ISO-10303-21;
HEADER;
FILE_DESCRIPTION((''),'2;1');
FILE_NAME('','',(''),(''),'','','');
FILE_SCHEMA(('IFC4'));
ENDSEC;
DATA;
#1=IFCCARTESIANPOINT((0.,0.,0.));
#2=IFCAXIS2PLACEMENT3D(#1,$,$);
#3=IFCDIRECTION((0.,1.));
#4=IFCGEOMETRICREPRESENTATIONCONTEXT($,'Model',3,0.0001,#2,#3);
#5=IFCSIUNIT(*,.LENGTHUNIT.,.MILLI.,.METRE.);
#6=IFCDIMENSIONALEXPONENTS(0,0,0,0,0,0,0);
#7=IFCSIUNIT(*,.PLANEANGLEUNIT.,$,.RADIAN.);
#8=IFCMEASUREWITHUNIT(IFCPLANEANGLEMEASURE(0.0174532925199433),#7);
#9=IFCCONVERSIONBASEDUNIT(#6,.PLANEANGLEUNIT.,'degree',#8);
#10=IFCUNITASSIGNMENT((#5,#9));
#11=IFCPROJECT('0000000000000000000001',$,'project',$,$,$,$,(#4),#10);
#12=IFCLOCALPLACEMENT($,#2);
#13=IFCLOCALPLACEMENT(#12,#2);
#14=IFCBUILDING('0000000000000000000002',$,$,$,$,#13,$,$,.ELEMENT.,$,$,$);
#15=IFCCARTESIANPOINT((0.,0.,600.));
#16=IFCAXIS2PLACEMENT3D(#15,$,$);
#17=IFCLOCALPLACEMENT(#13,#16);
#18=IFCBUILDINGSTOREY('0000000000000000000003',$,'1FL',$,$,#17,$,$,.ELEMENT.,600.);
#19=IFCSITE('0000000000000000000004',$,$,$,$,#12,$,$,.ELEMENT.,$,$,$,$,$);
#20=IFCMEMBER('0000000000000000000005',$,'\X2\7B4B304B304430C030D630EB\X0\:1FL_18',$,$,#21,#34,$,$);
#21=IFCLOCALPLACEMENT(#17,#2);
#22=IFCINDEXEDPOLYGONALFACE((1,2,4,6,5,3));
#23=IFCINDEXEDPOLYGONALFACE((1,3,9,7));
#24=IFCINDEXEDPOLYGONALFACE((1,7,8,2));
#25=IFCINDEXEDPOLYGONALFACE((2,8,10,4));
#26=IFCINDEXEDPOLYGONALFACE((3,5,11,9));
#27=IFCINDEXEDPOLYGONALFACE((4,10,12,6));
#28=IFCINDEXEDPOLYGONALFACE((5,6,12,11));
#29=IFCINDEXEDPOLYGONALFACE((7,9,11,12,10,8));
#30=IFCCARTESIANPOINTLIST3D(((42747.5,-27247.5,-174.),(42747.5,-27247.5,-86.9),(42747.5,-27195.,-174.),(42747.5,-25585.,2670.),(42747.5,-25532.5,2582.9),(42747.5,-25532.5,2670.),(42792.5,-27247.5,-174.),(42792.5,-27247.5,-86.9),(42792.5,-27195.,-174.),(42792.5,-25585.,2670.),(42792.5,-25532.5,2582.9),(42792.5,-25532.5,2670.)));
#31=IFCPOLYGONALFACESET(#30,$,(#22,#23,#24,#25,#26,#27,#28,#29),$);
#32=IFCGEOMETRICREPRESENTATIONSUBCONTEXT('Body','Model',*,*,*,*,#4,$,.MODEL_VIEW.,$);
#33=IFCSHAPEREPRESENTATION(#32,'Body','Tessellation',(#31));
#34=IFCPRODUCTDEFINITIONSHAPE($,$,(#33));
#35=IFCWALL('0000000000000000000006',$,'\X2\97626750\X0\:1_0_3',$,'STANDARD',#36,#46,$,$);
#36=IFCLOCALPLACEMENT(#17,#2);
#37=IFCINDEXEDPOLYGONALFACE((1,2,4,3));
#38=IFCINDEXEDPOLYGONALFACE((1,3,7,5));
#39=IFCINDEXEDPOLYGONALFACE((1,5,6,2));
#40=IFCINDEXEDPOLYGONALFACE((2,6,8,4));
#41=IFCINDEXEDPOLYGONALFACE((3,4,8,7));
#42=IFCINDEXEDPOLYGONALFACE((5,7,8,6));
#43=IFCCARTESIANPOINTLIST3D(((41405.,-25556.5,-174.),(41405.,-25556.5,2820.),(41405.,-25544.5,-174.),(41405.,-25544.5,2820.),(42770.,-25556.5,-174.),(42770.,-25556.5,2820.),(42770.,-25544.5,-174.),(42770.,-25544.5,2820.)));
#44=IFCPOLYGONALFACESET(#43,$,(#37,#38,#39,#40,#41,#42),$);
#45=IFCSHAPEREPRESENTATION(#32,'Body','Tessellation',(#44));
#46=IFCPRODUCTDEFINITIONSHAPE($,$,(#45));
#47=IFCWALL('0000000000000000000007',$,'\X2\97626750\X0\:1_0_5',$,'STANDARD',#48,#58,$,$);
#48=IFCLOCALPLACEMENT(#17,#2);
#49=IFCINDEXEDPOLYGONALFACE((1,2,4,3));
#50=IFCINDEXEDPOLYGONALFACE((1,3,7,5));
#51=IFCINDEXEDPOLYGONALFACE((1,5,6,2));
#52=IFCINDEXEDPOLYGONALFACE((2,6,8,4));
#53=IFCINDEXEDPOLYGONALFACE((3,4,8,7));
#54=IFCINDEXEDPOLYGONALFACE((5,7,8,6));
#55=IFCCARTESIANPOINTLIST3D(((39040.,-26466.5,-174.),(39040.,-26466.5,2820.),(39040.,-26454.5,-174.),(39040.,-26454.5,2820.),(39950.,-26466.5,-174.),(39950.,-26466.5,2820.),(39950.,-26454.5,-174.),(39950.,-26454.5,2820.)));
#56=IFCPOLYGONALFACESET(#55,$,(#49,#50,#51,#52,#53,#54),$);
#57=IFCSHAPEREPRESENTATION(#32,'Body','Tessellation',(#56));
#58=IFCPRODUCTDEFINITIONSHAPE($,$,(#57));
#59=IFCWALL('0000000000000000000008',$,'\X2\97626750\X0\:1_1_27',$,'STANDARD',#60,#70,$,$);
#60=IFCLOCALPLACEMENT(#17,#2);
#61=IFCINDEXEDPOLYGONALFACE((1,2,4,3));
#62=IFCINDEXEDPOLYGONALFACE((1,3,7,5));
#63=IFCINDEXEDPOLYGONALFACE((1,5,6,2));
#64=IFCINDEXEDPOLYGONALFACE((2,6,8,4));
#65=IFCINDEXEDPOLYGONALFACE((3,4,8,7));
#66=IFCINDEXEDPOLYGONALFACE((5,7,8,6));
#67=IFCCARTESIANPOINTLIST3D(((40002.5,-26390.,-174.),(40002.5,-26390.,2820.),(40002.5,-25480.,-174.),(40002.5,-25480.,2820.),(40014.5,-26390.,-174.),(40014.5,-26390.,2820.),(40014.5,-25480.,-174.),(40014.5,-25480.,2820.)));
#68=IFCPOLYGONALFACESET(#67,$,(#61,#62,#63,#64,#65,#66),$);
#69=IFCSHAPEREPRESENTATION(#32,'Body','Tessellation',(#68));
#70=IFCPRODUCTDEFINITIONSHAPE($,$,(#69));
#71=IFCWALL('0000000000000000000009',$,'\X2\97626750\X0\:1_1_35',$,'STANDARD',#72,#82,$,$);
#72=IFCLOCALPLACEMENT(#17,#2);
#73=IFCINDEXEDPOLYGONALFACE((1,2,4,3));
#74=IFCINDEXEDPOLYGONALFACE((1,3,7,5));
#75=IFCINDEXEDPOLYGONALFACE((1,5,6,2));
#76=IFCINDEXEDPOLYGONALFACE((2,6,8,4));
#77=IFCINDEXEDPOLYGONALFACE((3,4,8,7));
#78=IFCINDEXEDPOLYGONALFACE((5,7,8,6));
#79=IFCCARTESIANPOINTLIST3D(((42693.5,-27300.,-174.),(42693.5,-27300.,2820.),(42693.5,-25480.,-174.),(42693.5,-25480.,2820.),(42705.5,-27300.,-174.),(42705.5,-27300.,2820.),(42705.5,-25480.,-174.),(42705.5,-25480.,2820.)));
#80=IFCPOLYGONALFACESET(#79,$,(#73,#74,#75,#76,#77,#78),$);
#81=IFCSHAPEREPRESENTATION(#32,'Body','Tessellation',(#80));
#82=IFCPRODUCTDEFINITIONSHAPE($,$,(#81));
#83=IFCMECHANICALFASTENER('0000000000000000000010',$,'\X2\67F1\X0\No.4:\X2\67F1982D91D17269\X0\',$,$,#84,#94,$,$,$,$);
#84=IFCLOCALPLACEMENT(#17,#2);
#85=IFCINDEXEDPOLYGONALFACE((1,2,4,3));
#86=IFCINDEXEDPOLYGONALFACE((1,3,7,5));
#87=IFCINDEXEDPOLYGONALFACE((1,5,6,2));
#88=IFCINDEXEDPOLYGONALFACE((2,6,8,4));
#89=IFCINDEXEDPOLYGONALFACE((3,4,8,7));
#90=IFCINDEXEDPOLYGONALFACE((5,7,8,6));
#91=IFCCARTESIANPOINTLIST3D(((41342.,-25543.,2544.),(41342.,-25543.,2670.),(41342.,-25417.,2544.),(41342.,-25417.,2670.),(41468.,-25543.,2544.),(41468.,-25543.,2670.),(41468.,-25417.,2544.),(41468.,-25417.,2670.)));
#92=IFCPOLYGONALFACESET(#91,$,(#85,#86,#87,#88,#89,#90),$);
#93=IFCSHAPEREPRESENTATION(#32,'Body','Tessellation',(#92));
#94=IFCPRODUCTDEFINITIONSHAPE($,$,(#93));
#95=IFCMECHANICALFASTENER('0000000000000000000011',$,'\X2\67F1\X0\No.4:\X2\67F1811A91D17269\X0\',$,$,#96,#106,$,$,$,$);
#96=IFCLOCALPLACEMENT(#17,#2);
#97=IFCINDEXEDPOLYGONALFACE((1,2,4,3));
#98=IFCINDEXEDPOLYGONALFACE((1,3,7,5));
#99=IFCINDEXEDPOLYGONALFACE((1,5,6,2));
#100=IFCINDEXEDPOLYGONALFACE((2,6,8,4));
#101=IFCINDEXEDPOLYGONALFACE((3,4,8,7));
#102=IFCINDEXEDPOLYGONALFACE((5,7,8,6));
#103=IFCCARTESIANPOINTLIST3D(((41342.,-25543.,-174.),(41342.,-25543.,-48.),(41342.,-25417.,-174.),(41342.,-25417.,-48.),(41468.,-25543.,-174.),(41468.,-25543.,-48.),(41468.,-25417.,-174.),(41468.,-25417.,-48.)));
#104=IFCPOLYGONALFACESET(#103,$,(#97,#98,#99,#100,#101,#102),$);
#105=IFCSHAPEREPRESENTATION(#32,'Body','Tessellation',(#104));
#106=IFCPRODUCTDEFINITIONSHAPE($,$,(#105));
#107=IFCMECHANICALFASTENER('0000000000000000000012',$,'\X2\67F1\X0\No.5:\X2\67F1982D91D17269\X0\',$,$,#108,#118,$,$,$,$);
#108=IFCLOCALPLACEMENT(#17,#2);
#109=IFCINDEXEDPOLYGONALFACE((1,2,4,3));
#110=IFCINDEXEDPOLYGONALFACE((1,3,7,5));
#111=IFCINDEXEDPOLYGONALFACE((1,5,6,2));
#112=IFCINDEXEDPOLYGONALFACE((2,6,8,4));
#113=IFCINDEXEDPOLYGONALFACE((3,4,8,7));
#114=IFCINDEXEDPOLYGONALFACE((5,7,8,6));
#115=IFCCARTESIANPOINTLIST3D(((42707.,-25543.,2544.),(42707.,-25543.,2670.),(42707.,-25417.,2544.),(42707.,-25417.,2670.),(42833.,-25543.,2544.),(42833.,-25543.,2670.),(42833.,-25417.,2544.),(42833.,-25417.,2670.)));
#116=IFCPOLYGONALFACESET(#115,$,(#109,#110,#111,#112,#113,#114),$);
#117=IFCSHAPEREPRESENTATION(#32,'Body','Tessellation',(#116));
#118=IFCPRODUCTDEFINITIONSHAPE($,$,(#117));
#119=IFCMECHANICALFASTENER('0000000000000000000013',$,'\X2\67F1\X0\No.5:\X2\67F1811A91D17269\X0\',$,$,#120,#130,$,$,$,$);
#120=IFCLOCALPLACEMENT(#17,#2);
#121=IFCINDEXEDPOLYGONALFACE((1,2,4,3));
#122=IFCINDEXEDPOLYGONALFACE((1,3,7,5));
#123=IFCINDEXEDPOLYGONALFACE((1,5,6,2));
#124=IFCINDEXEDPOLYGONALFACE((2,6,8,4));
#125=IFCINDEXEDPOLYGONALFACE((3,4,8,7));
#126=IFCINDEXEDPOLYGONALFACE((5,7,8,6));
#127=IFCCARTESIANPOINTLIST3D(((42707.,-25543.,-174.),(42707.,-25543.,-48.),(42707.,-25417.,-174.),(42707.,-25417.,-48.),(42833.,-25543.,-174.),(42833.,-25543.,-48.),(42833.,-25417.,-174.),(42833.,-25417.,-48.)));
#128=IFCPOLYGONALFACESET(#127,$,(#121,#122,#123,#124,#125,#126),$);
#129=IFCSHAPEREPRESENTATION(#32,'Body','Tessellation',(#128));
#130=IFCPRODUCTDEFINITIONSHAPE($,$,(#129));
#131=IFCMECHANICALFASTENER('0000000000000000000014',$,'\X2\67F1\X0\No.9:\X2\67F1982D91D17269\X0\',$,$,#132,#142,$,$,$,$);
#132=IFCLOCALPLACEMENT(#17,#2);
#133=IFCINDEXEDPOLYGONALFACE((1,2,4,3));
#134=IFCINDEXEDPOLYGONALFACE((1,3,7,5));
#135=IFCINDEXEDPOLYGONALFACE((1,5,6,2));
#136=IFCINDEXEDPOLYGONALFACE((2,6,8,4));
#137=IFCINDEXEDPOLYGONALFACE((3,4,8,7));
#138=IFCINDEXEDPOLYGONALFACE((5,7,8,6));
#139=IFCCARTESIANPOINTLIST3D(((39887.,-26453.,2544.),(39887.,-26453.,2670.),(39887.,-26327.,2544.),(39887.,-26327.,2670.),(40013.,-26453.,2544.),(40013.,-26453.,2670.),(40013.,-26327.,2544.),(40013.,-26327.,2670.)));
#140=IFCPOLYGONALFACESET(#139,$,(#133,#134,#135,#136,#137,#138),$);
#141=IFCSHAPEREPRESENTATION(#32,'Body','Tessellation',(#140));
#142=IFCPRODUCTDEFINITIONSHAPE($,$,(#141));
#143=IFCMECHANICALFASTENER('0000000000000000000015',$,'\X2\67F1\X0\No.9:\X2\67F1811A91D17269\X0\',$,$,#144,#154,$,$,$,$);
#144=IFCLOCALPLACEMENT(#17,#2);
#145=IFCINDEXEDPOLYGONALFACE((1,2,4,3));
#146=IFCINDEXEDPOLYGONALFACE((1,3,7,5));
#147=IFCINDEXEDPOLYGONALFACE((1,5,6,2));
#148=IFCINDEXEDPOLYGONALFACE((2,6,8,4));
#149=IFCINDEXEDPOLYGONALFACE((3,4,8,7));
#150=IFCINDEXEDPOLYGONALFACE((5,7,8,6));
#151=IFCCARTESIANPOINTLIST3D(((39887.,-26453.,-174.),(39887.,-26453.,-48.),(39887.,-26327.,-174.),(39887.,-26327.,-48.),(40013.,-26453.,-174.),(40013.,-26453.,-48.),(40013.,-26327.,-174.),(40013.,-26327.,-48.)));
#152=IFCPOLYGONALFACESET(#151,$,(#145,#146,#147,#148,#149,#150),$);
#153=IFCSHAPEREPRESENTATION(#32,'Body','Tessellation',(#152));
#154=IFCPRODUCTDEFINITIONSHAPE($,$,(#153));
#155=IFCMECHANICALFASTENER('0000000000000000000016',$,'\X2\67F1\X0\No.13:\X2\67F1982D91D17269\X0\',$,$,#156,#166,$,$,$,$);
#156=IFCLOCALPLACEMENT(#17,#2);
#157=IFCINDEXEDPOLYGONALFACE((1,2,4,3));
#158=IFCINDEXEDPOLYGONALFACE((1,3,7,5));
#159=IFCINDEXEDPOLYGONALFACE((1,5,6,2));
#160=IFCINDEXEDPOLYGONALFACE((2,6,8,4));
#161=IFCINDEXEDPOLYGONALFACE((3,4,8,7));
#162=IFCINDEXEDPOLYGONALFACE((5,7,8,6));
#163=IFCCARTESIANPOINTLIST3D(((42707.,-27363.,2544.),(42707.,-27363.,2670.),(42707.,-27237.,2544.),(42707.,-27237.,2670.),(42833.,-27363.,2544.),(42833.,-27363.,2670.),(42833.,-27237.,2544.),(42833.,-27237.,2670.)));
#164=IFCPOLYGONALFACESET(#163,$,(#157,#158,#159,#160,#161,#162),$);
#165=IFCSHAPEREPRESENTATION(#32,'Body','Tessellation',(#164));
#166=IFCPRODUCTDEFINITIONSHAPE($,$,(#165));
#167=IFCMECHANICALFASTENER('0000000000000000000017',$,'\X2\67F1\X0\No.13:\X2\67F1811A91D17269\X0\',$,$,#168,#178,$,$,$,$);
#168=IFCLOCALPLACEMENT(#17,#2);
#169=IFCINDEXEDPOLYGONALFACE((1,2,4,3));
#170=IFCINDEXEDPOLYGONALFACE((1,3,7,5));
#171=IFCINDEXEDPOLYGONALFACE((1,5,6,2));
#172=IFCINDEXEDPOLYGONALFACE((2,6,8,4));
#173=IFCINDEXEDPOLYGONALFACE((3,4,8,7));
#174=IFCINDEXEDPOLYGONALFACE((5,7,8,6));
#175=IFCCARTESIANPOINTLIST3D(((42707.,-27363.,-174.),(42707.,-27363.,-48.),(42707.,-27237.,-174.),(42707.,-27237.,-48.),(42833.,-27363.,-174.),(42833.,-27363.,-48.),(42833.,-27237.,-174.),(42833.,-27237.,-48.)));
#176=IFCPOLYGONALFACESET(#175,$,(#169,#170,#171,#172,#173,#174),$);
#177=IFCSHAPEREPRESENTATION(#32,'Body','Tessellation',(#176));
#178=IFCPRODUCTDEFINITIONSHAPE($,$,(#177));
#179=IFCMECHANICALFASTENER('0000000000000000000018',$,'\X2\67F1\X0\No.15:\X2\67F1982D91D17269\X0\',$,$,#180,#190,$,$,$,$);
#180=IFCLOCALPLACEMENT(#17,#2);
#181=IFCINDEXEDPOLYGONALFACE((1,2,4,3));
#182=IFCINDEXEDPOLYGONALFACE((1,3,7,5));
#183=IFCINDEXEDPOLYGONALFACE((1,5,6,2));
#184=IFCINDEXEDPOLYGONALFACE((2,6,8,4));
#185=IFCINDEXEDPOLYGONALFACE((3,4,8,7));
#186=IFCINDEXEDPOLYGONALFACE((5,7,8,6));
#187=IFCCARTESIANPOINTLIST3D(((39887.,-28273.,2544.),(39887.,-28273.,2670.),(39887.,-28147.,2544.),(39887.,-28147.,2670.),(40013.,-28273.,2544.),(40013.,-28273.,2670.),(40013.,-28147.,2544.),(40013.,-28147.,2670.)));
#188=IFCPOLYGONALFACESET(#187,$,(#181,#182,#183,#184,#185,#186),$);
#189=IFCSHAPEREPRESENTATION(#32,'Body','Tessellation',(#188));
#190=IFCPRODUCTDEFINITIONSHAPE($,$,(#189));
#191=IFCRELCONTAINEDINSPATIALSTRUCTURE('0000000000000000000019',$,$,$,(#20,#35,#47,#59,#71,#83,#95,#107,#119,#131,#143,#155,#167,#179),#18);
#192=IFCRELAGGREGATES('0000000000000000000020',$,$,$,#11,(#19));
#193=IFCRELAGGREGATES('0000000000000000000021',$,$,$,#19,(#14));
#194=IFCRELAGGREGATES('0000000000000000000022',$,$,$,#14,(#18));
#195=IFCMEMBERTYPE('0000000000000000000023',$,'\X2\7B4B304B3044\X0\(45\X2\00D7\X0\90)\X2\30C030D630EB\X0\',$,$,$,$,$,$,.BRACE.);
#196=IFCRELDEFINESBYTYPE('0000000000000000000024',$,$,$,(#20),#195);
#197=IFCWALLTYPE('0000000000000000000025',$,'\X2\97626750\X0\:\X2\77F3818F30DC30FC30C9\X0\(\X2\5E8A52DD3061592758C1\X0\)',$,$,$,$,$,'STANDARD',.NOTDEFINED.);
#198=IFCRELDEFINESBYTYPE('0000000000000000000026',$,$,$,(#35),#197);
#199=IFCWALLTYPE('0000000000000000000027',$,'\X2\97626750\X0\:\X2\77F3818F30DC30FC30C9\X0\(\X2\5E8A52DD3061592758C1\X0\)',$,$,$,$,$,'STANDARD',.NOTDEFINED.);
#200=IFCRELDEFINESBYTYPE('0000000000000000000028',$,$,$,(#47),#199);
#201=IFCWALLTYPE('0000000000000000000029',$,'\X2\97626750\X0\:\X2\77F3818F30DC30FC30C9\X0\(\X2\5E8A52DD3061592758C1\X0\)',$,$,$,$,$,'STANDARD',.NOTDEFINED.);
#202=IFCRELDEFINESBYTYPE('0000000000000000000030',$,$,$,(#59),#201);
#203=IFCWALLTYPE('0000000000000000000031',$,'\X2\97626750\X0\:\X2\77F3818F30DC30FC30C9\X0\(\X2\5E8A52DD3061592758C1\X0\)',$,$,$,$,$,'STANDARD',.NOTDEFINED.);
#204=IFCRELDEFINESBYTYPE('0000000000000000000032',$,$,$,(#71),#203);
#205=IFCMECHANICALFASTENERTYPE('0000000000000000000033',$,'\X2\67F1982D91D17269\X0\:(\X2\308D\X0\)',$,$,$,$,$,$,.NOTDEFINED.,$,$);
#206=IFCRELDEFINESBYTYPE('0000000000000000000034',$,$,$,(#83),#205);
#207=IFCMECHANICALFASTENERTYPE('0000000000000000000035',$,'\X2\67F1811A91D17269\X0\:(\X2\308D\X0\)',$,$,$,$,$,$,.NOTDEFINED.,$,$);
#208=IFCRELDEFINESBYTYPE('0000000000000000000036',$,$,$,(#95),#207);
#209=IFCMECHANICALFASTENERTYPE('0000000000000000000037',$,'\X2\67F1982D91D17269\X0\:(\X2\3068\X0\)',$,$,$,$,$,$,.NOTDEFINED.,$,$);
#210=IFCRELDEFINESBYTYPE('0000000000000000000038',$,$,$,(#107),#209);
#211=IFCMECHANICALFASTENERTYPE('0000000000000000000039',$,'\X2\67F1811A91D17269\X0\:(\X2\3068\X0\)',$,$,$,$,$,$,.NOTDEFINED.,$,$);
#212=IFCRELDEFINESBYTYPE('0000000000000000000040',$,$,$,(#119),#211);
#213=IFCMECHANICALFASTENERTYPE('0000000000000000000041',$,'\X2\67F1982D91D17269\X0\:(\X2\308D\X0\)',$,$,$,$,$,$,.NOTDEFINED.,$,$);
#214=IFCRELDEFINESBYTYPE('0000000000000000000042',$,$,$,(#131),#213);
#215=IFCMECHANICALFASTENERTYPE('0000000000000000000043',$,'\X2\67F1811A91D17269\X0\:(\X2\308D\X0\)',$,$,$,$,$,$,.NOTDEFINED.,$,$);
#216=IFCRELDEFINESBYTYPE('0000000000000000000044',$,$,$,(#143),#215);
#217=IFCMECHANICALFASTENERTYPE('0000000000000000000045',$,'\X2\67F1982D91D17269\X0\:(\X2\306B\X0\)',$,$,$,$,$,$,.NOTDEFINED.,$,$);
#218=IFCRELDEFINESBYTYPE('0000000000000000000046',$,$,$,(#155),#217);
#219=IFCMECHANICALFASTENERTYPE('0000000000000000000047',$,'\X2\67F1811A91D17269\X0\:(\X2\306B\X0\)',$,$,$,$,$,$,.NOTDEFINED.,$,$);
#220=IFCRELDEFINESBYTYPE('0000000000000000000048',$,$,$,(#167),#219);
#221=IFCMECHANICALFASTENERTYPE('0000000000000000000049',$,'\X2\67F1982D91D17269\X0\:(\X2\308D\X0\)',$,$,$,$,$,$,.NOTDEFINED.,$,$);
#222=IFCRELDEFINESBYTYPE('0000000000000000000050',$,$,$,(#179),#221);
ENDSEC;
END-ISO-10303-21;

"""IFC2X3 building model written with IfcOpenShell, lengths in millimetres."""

from ifc_helpers import new_model, entity, si_unit, converted_unit, direction, frame, origin, origin_with_axes, origin_2d, place, context, subcontext, project, spatial, polyline, rectangle, outline, extrude, type_object, element, save


model = new_model("IFC2X3")

# Units and contexts
model_context = context("Model", 3, precision=0.0001, world=origin(), true_north=direction((0.0, 1.0)))
body_context = subcontext(model_context, "Body", "Model", "MODEL_VIEW")
ifc_project = project(units=[si_unit("LENGTHUNIT", "METRE", prefix="MILLI"), converted_unit("PLANEANGLEUNIT", "degree", entity("IfcPlaneAngleMeasure", 0.0174532925199433), si_unit("PLANEANGLEUNIT", "RADIAN"), dimensions=[0, 0, 0, 0, 0, 0, 0])], contexts=[model_context])

# Site, building, storey
site_placement = place(None, origin())
site = spatial("IfcSite", under=ifc_project, at=site_placement, CompositionType="ELEMENT")
building_placement = place(site_placement, origin())
building = spatial("IfcBuilding", under=site, at=building_placement, CompositionType="ELEMENT")
storey_placement = place(building_placement, frame((0.0, 0.0, 600.0)))
storey = spatial("IfcBuildingStorey", under=building, at=storey_placement, Name="1FL", CompositionType="ELEMENT", Elevation=600.0)

# Member
member_type_1 = type_object("IfcMemberType", Name="筋かい(45×90)ダブル", PredefinedType="BRACE")
member_1_placement = place(storey_placement, frame((42770.0, -27247.5, -174.0), z_axis=(0.0, 0.516399, 0.856348), x_axis=(0.0, -0.856348, 0.516399)))
element("IfcMember", 1, at=member_1_placement, inside=storey, type_object=member_type_1, Name="筋かいダブル:1FL_18", context=body_context, shape_type="SweptSolid", body=[
    extrude(outline(polyline([(0.0, 0.0), (27.1, -45.0), (3246.5, -45.0), (3321.1, 0.0), (3293.9, 45.0), (74.6, 45.0), (0.0, 0.0)])), frame((0.0, -22.5, 0.0), z_axis=(0.0, 1.0, 0.0), x_axis=(0.0, 0.0, 1.0)), (0.0, 0.0, 1.0), 45.0),
])

# Walls
wall_type_1 = type_object("IfcWallType", Name="面材:石膏ボード(床勝ち大壁)", ElementType="STANDARD", PredefinedType="NOTDEFINED")
wall_1_placement = place(storey_placement, frame((42087.5, -25544.5, -174.0), z_axis=(0.0, -1.0, 0.0), x_axis=(1.0, 0.0, 0.0)))
element("IfcWall", 2, at=wall_1_placement, inside=storey, type_object=wall_type_1, Name="面材:1_0_3", ObjectType="STANDARD", context=body_context, shape_type="SweptSolid", body=[
    extrude(outline(polyline([(682.5, 0.0, 0.0), (-682.5, 0.0, 0.0), (-682.5, 2994.0, 0.0), (682.5, 2994.0, 0.0), (682.5, 0.0, 0.0)])), origin_with_axes(), (0.0, 0.0, 1.0), 12.0),
])
wall_type_2 = type_object("IfcWallType", Name="面材:石膏ボード(床勝ち大壁)", ElementType="STANDARD", PredefinedType="NOTDEFINED")
wall_2_placement = place(storey_placement, frame((39495.0, -26454.5, -174.0), z_axis=(0.0, -1.0, 0.0), x_axis=(1.0, 0.0, 0.0)))
element("IfcWall", 3, at=wall_2_placement, inside=storey, type_object=wall_type_2, Name="面材:1_0_5", ObjectType="STANDARD", context=body_context, shape_type="SweptSolid", body=[
    extrude(outline(polyline([(455.0, 0.0, 0.0), (-455.0, 0.0, 0.0), (-455.0, 2994.0, 0.0), (455.0, 2994.0, 0.0), (455.0, 0.0, 0.0)])), origin_with_axes(), (0.0, 0.0, 1.0), 12.0),
])
wall_type_3 = type_object("IfcWallType", Name="面材:石膏ボード(床勝ち大壁)", ElementType="STANDARD", PredefinedType="NOTDEFINED")
wall_3_placement = place(storey_placement, frame((40014.5, -25935.0, -174.0), z_axis=(-1.0, 0.0, 0.0), x_axis=(0.0, -1.0, 0.0)))
element("IfcWall", 4, at=wall_3_placement, inside=storey, type_object=wall_type_3, Name="面材:1_1_27", ObjectType="STANDARD", context=body_context, shape_type="SweptSolid", body=[
    extrude(outline(polyline([(455.0, 0.0, 0.0), (-455.0, 0.0, 0.0), (-455.0, 2994.0, 0.0), (455.0, 2994.0, 0.0), (455.0, 0.0, 0.0)])), origin_with_axes(), (0.0, 0.0, 1.0), 12.0),
])
wall_type_4 = type_object("IfcWallType", Name="面材:石膏ボード(床勝ち大壁)", ElementType="STANDARD", PredefinedType="NOTDEFINED")
wall_4_placement = place(storey_placement, frame((42705.5, -26390.0, -174.0), z_axis=(-1.0, 0.0, 0.0), x_axis=(0.0, -1.0, 0.0)))
element("IfcWall", 5, at=wall_4_placement, inside=storey, type_object=wall_type_4, Name="面材:1_1_35", ObjectType="STANDARD", context=body_context, shape_type="SweptSolid", body=[
    extrude(outline(polyline([(910.0, 0.0, 0.0), (-910.0, 0.0, 0.0), (-910.0, 2994.0, 0.0), (910.0, 2994.0, 0.0), (910.0, 0.0, 0.0)])), origin_with_axes(), (0.0, 0.0, 1.0), 12.0),
])

# Mechanical fasteners
mechanical_fastener_type_1 = type_object("IfcMechanicalFastenerType", Name="柱頭金物:(ろ)")
mechanical_fastener_1_placement = place(storey_placement, frame((41405.0, -25480.0, 2544.0)))
element("IfcMechanicalFastener", 6, at=mechanical_fastener_1_placement, inside=storey, type_object=mechanical_fastener_type_1, Name="柱No.4:柱頭金物", context=body_context, shape_type="SweptSolid", body=[
    extrude(rectangle(XDim=126.0, YDim=126.0, at=origin_2d()), origin_with_axes(), (0.0, 0.0, 1.0), 126.0),
])
mechanical_fastener_type_2 = type_object("IfcMechanicalFastenerType", Name="柱脚金物:(ろ)")
mechanical_fastener_2_placement = place(storey_placement, frame((41405.0, -25480.0, -174.0)))
element("IfcMechanicalFastener", 7, at=mechanical_fastener_2_placement, inside=storey, type_object=mechanical_fastener_type_2, Name="柱No.4:柱脚金物", context=body_context, shape_type="SweptSolid", body=[
    extrude(rectangle(XDim=126.0, YDim=126.0, at=origin_2d()), origin_with_axes(), (0.0, 0.0, 1.0), 126.0),
])
mechanical_fastener_type_3 = type_object("IfcMechanicalFastenerType", Name="柱頭金物:(と)")
mechanical_fastener_3_placement = place(storey_placement, frame((42770.0, -25480.0, 2544.0)))
element("IfcMechanicalFastener", 8, at=mechanical_fastener_3_placement, inside=storey, type_object=mechanical_fastener_type_3, Name="柱No.5:柱頭金物", context=body_context, shape_type="SweptSolid", body=[
    extrude(rectangle(XDim=126.0, YDim=126.0, at=origin_2d()), origin_with_axes(), (0.0, 0.0, 1.0), 126.0),
])
mechanical_fastener_type_4 = type_object("IfcMechanicalFastenerType", Name="柱脚金物:(と)")
mechanical_fastener_4_placement = place(storey_placement, frame((42770.0, -25480.0, -174.0)))
element("IfcMechanicalFastener", 9, at=mechanical_fastener_4_placement, inside=storey, type_object=mechanical_fastener_type_4, Name="柱No.5:柱脚金物", context=body_context, shape_type="SweptSolid", body=[
    extrude(rectangle(XDim=126.0, YDim=126.0, at=origin_2d()), origin_with_axes(), (0.0, 0.0, 1.0), 126.0),
])
mechanical_fastener_type_5 = type_object("IfcMechanicalFastenerType", Name="柱頭金物:(ろ)")
mechanical_fastener_5_placement = place(storey_placement, frame((39950.0, -26390.0, 2544.0)))
element("IfcMechanicalFastener", 10, at=mechanical_fastener_5_placement, inside=storey, type_object=mechanical_fastener_type_5, Name="柱No.9:柱頭金物", context=body_context, shape_type="SweptSolid", body=[
    extrude(rectangle(XDim=126.0, YDim=126.0, at=origin_2d()), origin_with_axes(), (0.0, 0.0, 1.0), 126.0),
])
mechanical_fastener_type_6 = type_object("IfcMechanicalFastenerType", Name="柱脚金物:(ろ)")
mechanical_fastener_6_placement = place(storey_placement, frame((39950.0, -26390.0, -174.0)))
element("IfcMechanicalFastener", 11, at=mechanical_fastener_6_placement, inside=storey, type_object=mechanical_fastener_type_6, Name="柱No.9:柱脚金物", context=body_context, shape_type="SweptSolid", body=[
    extrude(rectangle(XDim=126.0, YDim=126.0, at=origin_2d()), origin_with_axes(), (0.0, 0.0, 1.0), 126.0),
])
mechanical_fastener_type_7 = type_object("IfcMechanicalFastenerType", Name="柱頭金物:(に)")
mechanical_fastener_7_placement = place(storey_placement, frame((42770.0, -27300.0, 2544.0)))
element("IfcMechanicalFastener", 12, at=mechanical_fastener_7_placement, inside=storey, type_object=mechanical_fastener_type_7, Name="柱No.13:柱頭金物", context=body_context, shape_type="SweptSolid", body=[
    extrude(rectangle(XDim=126.0, YDim=126.0, at=origin_2d()), origin_with_axes(), (0.0, 0.0, 1.0), 126.0),
])
mechanical_fastener_type_8 = type_object("IfcMechanicalFastenerType", Name="柱脚金物:(に)")
mechanical_fastener_8_placement = place(storey_placement, frame((42770.0, -27300.0, -174.0)))
element("IfcMechanicalFastener", 13, at=mechanical_fastener_8_placement, inside=storey, type_object=mechanical_fastener_type_8, Name="柱No.13:柱脚金物", context=body_context, shape_type="SweptSolid", body=[
    extrude(rectangle(XDim=126.0, YDim=126.0, at=origin_2d()), origin_with_axes(), (0.0, 0.0, 1.0), 126.0),
])
mechanical_fastener_type_9 = type_object("IfcMechanicalFastenerType", Name="柱頭金物:(ろ)")
mechanical_fastener_9_placement = place(storey_placement, frame((39950.0, -28210.0, 2544.0)))
element("IfcMechanicalFastener", 14, at=mechanical_fastener_9_placement, inside=storey, type_object=mechanical_fastener_type_9, Name="柱No.15:柱頭金物", context=body_context, shape_type="SweptSolid", body=[
    extrude(rectangle(XDim=126.0, YDim=126.0, at=origin_2d()), origin_with_axes(), (0.0, 0.0, 1.0), 126.0),
])

save(model, "model.ifc")
